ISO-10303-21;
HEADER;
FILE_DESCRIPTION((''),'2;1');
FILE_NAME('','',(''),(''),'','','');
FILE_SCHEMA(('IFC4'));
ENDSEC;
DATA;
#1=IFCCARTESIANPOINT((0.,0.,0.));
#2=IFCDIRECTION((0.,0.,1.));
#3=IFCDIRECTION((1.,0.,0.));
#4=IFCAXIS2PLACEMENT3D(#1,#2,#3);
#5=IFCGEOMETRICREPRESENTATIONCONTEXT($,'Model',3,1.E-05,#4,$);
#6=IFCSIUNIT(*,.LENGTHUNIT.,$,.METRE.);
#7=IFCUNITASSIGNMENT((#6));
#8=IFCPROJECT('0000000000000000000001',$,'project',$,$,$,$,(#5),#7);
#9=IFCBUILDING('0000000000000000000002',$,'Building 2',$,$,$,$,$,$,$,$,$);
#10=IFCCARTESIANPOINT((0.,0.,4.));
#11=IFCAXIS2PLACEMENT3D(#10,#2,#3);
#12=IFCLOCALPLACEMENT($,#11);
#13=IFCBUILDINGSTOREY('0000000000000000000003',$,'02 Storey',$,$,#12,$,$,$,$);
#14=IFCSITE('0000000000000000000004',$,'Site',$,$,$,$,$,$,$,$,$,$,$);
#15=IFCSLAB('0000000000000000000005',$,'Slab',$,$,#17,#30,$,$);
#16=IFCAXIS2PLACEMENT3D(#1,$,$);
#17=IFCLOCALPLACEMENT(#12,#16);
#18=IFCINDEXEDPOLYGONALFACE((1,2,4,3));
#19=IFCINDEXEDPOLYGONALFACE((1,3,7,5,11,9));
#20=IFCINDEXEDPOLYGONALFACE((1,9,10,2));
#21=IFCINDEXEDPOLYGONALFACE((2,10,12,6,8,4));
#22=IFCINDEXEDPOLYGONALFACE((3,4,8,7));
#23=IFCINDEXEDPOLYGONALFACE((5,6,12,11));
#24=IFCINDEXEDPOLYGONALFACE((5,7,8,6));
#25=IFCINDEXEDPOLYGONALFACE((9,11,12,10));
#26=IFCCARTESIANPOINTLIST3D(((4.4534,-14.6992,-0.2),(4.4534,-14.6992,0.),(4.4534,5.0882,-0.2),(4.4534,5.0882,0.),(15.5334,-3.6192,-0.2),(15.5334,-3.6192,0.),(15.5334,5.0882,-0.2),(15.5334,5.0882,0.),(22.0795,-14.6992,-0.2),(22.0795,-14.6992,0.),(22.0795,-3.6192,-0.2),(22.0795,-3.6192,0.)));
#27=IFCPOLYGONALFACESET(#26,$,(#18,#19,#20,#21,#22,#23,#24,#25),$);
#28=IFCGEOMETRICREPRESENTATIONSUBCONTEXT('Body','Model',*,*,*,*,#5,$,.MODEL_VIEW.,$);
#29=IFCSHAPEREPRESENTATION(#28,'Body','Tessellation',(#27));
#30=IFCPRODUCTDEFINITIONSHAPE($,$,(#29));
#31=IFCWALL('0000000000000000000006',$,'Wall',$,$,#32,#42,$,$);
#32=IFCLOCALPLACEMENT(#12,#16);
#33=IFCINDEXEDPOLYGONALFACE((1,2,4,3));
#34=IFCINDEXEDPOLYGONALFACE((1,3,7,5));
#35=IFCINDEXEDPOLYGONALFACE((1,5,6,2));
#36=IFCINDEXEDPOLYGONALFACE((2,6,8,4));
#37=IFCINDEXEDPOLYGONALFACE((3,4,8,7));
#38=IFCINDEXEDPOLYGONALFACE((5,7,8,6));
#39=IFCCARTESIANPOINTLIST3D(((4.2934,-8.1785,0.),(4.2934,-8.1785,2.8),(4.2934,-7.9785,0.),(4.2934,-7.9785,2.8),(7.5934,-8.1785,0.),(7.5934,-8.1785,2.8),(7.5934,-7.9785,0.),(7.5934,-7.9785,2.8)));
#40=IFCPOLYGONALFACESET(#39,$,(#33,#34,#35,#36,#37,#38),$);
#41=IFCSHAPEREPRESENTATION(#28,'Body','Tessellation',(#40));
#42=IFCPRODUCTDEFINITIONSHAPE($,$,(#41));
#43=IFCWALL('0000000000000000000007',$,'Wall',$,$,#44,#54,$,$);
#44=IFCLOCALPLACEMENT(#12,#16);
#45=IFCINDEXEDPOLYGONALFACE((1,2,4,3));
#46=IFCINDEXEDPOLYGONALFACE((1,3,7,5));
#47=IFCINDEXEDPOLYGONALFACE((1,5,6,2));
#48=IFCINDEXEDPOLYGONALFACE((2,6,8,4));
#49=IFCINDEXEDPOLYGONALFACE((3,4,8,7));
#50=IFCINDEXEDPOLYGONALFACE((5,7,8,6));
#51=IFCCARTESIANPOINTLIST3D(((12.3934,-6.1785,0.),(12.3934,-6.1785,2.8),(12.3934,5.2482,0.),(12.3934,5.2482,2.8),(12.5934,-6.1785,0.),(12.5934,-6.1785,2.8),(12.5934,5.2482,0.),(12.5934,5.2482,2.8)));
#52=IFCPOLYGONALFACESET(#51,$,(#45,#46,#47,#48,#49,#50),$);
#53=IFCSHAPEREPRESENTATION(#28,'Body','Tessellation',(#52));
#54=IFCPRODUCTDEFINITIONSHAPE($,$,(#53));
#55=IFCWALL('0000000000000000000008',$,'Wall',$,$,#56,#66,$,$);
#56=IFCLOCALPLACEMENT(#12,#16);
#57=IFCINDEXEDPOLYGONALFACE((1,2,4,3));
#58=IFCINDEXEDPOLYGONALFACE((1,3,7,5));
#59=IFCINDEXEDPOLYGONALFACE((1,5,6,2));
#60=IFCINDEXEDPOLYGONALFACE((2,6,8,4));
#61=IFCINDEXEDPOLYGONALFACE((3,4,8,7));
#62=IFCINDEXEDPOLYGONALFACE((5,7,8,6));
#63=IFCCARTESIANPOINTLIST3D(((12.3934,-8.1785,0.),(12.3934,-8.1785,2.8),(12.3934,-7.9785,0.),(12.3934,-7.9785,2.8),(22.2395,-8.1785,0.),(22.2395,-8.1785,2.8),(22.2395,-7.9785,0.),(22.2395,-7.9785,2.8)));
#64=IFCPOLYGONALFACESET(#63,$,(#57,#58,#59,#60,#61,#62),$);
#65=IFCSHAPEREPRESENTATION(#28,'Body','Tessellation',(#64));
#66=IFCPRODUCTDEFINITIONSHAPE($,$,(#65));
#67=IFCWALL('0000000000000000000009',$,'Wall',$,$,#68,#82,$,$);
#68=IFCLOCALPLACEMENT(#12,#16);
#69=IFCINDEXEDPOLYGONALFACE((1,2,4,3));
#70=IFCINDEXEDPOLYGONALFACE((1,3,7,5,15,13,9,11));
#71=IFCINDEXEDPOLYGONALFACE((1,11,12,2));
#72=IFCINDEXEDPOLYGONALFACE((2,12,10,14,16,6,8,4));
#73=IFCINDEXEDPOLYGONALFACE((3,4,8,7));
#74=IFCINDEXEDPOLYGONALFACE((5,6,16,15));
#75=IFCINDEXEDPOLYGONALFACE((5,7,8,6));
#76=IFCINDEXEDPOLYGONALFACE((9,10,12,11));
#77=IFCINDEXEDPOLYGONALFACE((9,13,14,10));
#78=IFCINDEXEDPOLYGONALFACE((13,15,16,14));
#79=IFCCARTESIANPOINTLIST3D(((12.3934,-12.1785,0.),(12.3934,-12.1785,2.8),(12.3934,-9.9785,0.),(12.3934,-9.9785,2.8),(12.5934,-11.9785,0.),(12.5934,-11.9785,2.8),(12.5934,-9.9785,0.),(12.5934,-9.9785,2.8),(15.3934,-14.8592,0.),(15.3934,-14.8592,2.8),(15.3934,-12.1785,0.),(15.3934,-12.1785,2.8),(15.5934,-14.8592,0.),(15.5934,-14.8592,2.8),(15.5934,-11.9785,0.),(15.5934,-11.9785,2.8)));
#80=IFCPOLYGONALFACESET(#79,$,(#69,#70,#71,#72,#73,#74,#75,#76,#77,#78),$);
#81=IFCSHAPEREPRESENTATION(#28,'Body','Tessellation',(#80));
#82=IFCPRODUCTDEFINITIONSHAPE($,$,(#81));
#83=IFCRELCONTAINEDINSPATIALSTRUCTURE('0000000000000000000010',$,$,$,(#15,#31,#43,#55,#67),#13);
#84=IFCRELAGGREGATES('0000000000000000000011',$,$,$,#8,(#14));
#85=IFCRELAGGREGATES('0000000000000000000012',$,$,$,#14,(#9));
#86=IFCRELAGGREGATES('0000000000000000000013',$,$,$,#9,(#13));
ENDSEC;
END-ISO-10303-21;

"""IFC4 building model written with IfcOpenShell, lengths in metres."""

from ifc_helpers import new_model, si_unit, frame, origin_with_axes, place, context, subcontext, project, spatial, line, indexed_curve, outline, extrude, element, save


model = new_model("IFC4")

# Units and contexts
model_context = context("Model", 3, precision=1e-05, world=origin_with_axes())
body_context = subcontext(model_context, "Body", "Model", "MODEL_VIEW")
ifc_project = project(units=[si_unit("LENGTHUNIT", "METRE")], contexts=[model_context])

# Site, building, storey
site = spatial("IfcSite", under=ifc_project, Name="Site")
building = spatial("IfcBuilding", under=site, Name="Building 2")
storey_placement = place(None, frame((0.0, 0.0, 4.0), z_axis=(0.0, 0.0, 1.0), x_axis=(1.0, 0.0, 0.0)))
storey = spatial("IfcBuildingStorey", under=building, at=storey_placement, Name="02 Storey")

# Slab
slab_placement = place(storey_placement, origin_with_axes())
element("IfcSlab", 1, at=slab_placement, inside=storey, Name="Slab", context=body_context, shape_type="SweptSolid", body=[
    extrude(outline(indexed_curve([(22.0795, -3.6192), (15.5334, -3.6192), (15.5334, 5.0882), (4.4534, 5.0882), (4.4534, -14.6992), (22.0795, -14.6992)], segments=[line(1, 2), line(2, 3), line(3, 4), line(4, 5), line(5, 6)])), origin_with_axes(), (0.0, 0.0, -1.0), 0.2),
])

# Walls
wall_1_placement = place(storey_placement, origin_with_axes())
element("IfcWall", 2, at=wall_1_placement, inside=storey, Name="Wall", context=body_context, shape_type="SweptSolid", body=[
    extrude(outline(indexed_curve([(7.5934, -7.9785), (4.2934, -7.9785), (4.2934, -8.1785), (7.5934, -8.1785)], segments=[line(1, 2), line(2, 3), line(3, 4)])), origin_with_axes(), (0.0, 0.0, 1.0), 2.8),
])
wall_2_placement = place(storey_placement, origin_with_axes())
element("IfcWall", 3, at=wall_2_placement, inside=storey, Name="Wall", context=body_context, shape_type="SweptSolid", body=[
    extrude(outline(indexed_curve([(12.5934, 5.2482), (12.3934, 5.2482), (12.3934, -6.1785), (12.5934, -6.1785)], segments=[line(1, 2), line(2, 3), line(3, 4)])), origin_with_axes(), (0.0, 0.0, 1.0), 2.8),
])
wall_3_placement = place(storey_placement, origin_with_axes())
element("IfcWall", 4, at=wall_3_placement, inside=storey, Name="Wall", context=body_context, shape_type="SweptSolid", body=[
    extrude(outline(indexed_curve([(22.2395, -7.9785), (12.3934, -7.9785), (12.3934, -8.1785), (22.2395, -8.1785)], segments=[line(1, 2), line(2, 3), line(3, 4)])), origin_with_axes(), (0.0, 0.0, 1.0), 2.8),
])
wall_4_placement = place(storey_placement, origin_with_axes())
element("IfcWall", 5, at=wall_4_placement, inside=storey, Name="Wall", context=body_context, shape_type="SweptSolid", body=[
    extrude(outline(indexed_curve([(15.5934, -11.9785), (12.5934, -11.9785), (12.5934, -9.9785), (12.3934, -9.9785), (12.3934, -12.1785), (15.3934, -12.1785), (15.3934, -14.8592), (15.5934, -14.8592)], segments=[line(1, 2), line(2, 3), line(3, 4), line(4, 5), line(5, 6), line(6, 7), line(7, 8)])), origin_with_axes(), (0.0, 0.0, 1.0), 2.8),
])

save(model, "model.ifc")
